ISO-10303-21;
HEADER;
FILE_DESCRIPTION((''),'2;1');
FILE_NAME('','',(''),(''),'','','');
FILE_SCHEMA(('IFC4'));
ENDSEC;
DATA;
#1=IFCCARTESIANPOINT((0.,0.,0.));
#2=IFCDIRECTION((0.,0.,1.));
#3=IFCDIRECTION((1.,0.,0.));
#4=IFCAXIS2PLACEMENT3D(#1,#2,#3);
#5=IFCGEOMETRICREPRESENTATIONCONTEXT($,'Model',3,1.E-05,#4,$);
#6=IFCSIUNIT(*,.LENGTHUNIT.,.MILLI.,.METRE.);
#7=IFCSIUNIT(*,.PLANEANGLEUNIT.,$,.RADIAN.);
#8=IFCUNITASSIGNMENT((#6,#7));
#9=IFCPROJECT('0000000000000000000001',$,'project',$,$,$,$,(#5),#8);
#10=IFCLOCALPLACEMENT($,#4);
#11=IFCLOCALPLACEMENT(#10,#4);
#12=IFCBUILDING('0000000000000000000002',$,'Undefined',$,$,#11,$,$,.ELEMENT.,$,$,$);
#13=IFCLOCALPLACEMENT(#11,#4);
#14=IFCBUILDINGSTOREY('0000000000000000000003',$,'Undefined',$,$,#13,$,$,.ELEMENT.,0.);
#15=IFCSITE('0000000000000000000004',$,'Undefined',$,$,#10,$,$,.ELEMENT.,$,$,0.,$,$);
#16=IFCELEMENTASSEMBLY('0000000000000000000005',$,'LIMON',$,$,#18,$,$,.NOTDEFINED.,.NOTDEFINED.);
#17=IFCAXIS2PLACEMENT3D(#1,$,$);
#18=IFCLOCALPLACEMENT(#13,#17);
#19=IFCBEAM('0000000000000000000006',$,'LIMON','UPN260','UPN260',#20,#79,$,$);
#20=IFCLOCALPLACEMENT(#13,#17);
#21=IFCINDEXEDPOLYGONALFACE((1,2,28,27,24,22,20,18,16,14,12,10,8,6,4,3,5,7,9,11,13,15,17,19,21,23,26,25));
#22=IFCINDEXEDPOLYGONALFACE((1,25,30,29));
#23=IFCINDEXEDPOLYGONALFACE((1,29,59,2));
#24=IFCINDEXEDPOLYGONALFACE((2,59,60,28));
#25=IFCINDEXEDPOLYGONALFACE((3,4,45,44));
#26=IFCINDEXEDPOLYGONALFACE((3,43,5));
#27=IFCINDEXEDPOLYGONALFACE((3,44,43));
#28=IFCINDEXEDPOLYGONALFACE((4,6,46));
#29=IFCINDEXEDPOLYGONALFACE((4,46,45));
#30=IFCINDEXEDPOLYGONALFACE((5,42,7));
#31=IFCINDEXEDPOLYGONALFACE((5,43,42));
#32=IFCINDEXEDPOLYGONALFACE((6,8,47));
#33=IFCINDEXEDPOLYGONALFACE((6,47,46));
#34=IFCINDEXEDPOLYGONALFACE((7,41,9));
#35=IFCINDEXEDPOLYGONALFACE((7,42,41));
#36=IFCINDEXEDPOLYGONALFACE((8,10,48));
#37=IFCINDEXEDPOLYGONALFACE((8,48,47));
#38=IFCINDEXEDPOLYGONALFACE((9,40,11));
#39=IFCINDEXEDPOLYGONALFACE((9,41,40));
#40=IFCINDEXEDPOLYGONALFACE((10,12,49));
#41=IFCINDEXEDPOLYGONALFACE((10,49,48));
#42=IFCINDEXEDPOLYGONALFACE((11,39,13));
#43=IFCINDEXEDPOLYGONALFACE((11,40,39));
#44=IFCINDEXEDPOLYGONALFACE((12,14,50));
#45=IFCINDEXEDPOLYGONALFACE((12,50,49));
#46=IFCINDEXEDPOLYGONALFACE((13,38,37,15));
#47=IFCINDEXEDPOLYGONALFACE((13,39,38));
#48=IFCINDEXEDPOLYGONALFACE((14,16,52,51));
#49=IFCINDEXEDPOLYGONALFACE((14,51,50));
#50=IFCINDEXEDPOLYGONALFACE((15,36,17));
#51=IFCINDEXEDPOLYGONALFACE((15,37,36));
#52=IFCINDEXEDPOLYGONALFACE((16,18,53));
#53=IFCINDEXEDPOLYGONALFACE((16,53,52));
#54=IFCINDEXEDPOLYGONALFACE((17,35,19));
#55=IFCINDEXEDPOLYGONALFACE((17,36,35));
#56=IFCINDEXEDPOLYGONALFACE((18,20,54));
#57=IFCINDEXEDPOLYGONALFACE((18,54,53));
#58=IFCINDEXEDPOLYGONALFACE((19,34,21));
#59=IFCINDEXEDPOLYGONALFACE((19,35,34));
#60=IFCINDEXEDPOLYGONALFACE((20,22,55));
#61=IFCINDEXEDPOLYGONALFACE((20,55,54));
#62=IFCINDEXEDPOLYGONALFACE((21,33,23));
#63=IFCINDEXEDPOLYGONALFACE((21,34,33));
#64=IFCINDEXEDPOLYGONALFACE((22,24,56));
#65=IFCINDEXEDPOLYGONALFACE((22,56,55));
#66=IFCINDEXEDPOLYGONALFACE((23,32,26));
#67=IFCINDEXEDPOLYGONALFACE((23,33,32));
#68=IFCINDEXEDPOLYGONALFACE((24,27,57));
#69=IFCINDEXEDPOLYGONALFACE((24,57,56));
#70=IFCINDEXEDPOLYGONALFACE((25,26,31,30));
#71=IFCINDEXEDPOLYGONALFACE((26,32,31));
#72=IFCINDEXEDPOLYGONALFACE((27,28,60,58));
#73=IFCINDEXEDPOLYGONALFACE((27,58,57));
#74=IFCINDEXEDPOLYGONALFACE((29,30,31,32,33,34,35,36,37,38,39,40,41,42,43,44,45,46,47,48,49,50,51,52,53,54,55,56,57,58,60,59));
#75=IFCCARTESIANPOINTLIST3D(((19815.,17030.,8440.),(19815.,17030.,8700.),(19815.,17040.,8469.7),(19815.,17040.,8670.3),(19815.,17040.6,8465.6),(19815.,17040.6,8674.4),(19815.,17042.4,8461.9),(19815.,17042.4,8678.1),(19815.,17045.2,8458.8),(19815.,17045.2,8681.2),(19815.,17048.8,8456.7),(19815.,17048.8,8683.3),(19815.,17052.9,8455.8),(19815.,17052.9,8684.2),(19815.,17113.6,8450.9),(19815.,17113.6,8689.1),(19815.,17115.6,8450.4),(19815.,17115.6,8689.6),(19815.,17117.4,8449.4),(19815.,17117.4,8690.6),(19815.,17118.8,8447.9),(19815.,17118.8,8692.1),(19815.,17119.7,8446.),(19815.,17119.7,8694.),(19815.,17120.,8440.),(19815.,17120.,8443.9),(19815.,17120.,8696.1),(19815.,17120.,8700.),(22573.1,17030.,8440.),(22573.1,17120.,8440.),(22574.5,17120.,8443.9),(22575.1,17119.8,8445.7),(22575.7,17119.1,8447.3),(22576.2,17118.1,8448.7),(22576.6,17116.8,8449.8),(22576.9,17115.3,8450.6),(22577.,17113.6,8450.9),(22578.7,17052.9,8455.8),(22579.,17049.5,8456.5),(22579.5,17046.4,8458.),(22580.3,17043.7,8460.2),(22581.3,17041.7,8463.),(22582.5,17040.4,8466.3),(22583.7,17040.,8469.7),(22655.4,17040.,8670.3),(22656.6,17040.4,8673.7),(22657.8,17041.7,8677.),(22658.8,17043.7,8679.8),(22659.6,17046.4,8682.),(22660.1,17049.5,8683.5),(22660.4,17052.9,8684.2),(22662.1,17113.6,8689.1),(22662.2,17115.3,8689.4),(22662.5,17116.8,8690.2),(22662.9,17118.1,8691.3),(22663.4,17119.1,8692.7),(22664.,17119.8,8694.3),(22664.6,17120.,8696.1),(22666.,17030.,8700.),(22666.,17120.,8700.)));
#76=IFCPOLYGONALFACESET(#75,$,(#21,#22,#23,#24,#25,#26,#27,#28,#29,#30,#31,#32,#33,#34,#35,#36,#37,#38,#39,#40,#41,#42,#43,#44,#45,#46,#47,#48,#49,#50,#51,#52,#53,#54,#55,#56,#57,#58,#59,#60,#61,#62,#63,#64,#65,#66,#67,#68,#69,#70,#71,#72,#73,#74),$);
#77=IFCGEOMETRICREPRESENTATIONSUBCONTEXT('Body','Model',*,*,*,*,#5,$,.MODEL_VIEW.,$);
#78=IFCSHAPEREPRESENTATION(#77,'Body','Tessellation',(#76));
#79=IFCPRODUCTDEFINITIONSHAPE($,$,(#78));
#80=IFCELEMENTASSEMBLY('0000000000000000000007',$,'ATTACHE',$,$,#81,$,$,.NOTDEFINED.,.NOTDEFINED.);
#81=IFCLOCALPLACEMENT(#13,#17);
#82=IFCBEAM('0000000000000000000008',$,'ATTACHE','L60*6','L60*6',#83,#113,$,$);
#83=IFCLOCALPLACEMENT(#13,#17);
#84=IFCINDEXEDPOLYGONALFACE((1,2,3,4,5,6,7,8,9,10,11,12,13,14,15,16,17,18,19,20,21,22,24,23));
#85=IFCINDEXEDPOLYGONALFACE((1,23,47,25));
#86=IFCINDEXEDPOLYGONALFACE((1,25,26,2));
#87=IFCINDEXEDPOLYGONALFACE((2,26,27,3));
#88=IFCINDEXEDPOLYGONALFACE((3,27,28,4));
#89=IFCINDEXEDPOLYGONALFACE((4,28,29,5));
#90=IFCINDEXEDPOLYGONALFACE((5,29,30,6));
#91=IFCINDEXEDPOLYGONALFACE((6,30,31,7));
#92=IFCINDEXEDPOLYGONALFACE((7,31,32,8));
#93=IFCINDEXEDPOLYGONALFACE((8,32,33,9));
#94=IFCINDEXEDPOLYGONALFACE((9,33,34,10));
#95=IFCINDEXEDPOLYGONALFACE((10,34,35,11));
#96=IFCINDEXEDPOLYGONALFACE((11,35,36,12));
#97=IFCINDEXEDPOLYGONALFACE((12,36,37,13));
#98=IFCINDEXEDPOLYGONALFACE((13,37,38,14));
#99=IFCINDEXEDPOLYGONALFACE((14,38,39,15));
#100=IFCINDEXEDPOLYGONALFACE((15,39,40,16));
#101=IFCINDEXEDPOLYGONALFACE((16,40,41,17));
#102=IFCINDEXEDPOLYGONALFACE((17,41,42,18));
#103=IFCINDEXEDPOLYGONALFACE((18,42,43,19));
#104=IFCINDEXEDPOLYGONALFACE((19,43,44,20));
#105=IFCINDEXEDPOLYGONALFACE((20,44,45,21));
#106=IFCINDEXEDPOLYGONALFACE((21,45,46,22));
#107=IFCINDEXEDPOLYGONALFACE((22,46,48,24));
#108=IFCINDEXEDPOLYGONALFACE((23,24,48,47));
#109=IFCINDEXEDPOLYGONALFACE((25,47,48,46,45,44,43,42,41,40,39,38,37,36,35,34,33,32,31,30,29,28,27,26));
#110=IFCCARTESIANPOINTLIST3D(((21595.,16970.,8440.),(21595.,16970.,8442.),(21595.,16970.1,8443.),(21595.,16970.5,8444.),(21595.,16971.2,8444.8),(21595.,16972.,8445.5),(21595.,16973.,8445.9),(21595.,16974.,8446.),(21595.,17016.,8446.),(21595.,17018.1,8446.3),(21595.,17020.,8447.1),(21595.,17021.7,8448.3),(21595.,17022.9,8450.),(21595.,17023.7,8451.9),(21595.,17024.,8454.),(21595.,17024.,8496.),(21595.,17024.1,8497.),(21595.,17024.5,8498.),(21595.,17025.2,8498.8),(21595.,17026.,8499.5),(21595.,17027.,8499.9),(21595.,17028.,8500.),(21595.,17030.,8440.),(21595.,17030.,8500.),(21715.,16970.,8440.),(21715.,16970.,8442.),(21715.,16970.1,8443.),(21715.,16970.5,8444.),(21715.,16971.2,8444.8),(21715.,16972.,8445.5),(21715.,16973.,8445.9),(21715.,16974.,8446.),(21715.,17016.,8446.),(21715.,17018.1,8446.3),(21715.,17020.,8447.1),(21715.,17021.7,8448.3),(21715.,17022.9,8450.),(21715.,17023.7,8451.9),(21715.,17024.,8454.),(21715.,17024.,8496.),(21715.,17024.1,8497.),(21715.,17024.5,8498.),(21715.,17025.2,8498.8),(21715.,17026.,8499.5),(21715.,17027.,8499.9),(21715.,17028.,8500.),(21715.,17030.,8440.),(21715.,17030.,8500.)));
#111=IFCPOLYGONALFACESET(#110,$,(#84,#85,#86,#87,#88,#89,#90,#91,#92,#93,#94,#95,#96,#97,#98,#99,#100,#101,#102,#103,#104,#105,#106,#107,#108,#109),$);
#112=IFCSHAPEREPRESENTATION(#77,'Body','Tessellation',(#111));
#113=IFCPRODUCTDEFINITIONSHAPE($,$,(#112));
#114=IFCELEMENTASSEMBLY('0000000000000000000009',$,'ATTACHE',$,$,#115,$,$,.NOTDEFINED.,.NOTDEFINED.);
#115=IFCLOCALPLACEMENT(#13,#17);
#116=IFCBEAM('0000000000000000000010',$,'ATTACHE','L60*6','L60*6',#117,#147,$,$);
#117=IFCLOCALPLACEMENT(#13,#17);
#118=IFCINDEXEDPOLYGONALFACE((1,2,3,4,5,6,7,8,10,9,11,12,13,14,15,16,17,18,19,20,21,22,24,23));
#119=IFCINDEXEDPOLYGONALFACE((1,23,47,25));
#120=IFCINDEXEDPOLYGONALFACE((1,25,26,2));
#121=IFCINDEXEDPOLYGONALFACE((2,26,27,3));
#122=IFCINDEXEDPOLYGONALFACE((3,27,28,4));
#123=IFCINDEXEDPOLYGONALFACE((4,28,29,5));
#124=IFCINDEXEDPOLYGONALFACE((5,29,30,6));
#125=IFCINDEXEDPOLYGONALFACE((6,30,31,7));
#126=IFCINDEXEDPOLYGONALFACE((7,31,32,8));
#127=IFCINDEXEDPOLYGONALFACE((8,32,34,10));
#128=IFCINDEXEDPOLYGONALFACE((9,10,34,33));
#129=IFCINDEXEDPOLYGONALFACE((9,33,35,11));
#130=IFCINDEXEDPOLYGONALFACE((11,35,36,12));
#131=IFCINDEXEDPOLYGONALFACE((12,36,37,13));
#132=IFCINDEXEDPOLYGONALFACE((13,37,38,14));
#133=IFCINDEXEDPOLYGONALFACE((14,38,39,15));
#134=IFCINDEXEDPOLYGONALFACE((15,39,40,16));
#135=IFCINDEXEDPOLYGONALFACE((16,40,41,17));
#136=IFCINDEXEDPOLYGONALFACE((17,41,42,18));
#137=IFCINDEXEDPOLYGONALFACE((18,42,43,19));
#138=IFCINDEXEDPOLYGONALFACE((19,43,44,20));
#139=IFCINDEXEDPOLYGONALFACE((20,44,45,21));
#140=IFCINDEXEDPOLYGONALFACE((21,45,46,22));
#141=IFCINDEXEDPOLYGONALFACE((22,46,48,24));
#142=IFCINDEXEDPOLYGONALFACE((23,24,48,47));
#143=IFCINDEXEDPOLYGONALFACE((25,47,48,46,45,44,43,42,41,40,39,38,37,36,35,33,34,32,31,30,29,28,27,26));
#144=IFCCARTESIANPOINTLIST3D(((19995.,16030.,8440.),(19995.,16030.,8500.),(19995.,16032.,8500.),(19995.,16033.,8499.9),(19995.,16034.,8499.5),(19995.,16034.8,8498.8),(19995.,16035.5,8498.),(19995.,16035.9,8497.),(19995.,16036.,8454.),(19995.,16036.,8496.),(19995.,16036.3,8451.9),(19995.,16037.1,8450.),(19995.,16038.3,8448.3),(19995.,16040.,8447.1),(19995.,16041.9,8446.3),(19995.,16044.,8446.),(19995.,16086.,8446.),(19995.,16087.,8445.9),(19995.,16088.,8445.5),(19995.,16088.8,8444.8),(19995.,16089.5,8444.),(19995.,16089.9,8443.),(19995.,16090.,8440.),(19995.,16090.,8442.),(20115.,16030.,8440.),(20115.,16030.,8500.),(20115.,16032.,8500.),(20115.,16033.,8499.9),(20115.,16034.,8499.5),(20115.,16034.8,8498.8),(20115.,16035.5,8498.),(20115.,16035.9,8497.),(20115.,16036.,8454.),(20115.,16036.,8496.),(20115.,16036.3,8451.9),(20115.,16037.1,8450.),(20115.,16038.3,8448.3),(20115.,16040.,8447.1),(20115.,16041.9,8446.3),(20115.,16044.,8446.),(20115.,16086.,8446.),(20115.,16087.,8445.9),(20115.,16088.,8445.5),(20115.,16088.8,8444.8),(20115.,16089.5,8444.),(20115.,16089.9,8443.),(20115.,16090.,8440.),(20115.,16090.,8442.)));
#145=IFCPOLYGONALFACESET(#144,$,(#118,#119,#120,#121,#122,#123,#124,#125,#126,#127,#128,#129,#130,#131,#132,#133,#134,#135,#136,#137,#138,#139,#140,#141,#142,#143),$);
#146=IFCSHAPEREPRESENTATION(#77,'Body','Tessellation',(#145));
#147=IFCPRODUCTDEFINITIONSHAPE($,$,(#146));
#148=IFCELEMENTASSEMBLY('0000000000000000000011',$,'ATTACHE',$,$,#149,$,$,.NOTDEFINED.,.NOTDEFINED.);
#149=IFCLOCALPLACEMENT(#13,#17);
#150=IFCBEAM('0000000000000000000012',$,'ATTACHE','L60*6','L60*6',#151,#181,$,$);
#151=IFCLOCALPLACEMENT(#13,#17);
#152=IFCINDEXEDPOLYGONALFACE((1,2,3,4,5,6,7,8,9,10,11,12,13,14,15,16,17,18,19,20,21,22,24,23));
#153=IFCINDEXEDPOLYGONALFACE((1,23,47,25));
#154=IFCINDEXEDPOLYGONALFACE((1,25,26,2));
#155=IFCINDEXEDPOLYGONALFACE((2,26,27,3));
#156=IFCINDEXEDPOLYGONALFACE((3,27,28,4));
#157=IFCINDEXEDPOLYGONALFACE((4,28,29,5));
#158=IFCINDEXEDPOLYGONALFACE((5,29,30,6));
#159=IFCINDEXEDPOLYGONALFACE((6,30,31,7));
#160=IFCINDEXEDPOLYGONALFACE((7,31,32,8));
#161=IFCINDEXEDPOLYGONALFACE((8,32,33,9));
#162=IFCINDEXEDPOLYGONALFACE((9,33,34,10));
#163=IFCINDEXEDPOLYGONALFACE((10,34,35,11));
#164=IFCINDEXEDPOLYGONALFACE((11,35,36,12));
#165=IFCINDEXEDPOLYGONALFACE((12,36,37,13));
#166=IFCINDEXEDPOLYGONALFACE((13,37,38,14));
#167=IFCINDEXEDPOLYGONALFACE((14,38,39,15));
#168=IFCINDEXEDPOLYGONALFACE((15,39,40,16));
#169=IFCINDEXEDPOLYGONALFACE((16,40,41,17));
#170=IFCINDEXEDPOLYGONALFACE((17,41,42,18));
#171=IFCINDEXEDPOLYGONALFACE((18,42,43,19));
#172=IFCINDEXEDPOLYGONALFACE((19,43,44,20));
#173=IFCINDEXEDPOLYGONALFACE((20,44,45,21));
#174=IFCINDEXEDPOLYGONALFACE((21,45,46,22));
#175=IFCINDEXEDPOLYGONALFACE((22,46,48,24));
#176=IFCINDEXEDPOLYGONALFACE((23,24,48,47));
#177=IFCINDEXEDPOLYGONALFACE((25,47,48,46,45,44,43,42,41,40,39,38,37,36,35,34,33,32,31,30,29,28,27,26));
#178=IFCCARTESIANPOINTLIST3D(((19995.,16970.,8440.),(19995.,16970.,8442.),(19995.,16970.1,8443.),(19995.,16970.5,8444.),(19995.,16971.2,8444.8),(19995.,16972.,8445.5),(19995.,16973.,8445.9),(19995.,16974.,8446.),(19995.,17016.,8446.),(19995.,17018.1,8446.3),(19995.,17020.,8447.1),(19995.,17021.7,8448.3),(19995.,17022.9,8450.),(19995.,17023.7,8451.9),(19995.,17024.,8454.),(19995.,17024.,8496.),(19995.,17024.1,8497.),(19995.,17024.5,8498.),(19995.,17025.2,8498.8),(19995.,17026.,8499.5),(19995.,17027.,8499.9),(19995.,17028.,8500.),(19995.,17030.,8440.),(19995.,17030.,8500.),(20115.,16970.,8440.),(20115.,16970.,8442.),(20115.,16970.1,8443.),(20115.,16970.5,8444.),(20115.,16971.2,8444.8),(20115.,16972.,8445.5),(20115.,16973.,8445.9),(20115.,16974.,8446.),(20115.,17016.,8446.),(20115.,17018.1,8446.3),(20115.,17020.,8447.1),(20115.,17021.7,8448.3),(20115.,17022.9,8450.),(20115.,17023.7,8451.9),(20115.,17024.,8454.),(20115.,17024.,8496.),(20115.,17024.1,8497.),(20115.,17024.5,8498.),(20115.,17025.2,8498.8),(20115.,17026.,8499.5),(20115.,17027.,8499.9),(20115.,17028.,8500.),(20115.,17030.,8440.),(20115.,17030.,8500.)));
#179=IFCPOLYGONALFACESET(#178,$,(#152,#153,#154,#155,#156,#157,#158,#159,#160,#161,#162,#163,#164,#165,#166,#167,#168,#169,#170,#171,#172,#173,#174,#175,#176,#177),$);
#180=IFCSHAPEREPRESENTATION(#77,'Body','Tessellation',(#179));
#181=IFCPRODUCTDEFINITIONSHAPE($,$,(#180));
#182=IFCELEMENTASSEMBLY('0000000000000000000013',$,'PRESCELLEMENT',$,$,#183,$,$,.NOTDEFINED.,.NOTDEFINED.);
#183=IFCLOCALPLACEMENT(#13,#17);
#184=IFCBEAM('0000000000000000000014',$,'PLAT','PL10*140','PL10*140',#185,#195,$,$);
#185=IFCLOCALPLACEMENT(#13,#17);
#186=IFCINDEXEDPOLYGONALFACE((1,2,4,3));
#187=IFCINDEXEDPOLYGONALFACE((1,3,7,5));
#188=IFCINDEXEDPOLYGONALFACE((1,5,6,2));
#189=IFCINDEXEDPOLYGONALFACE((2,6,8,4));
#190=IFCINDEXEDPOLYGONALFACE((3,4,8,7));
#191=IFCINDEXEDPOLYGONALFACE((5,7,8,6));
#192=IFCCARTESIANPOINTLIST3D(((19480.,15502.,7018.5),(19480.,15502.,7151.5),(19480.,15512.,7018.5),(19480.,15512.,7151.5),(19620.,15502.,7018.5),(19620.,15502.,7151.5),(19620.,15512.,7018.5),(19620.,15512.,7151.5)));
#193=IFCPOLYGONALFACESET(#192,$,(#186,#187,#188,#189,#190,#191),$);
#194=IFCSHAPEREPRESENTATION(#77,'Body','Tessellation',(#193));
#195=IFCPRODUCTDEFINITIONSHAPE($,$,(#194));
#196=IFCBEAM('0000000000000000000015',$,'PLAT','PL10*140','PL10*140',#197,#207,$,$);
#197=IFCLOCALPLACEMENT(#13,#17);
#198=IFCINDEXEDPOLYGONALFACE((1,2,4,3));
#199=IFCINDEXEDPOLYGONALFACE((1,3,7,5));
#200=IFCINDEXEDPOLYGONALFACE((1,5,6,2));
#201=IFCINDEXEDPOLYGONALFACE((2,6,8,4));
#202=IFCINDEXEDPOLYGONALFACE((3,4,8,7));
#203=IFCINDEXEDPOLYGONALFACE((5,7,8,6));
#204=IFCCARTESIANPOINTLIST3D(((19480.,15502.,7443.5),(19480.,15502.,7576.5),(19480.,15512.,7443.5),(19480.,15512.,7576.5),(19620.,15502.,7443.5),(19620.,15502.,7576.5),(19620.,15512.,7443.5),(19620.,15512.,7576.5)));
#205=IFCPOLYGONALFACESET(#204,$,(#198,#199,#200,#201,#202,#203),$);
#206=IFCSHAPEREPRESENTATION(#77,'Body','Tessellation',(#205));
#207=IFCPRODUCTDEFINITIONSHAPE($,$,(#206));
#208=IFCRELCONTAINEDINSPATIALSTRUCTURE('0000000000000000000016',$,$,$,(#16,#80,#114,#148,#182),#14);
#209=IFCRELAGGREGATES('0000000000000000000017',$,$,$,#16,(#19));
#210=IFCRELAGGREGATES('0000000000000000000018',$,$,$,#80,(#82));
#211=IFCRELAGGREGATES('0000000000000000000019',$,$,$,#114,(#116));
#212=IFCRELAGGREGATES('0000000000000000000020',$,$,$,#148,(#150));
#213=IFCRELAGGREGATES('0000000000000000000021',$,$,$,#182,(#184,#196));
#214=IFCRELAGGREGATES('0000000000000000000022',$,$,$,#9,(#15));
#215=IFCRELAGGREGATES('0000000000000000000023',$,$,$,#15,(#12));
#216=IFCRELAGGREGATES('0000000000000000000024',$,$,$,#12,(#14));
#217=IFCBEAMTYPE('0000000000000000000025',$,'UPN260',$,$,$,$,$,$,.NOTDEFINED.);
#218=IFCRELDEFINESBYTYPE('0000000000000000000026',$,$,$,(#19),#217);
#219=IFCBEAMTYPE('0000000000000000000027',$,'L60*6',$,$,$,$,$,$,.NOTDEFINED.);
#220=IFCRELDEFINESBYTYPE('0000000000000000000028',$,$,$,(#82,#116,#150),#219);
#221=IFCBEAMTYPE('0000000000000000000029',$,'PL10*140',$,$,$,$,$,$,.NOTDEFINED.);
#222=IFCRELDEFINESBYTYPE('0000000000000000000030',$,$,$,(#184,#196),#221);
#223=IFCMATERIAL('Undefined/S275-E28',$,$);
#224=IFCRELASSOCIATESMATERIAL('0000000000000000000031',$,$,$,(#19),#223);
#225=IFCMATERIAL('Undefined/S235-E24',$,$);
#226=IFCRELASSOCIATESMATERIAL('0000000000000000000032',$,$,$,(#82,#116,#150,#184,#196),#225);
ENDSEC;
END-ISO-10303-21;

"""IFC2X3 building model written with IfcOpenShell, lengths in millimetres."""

from ifc_helpers import new_model, si_unit, frame, origin_with_axes, origin_2d_with_axis, place, context, subcontext, project, spatial, rectangle, l_section, u_section, extrude, clip, halfspace, material, type_object, element, aggregate, save


model = new_model("IFC2X3")

# Units and contexts
model_context = context("Model", 3, precision=1e-05, world=origin_with_axes())
body_context = subcontext(model_context, "Body", "Model", "MODEL_VIEW")
ifc_project = project(units=[si_unit("LENGTHUNIT", "METRE", prefix="MILLI"), si_unit("PLANEANGLEUNIT", "RADIAN")], contexts=[model_context])

# Site, building, storey
site_placement = place(None, origin_with_axes())
site = spatial("IfcSite", under=ifc_project, at=site_placement, Name="Undefined", CompositionType="ELEMENT", RefElevation=0.0)
building_placement = place(site_placement, origin_with_axes())
building = spatial("IfcBuilding", under=site, at=building_placement, Name="Undefined", CompositionType="ELEMENT")
storey_placement = place(building_placement, origin_with_axes())
storey = spatial("IfcBuildingStorey", under=building, at=storey_placement, Name="Undefined", CompositionType="ELEMENT", Elevation=0.0)

# Shared definitions
ifc_material_1 = material(Name="Undefined/S235-E24")

# Element assemblies, beams
assembly_1_placement = place(storey_placement, origin_with_axes())
assembly_1 = element("IfcElementAssembly", 1, at=assembly_1_placement, inside=storey, Name="LIMON", AssemblyPlace="NOTDEFINED", PredefinedType="NOTDEFINED")
ifc_material_2 = material(Name="Undefined/S275-E28")
beam_type_1 = type_object("IfcBeamType", Name="UPN260", PredefinedType="NOTDEFINED")
beam_1_placement = place(assembly_1_placement, frame((19815.0, 17075.0, 8570.0), z_axis=(0.0, 0.0, -1.0), x_axis=(1.0, -0.000002, 0.0)))
beam_1 = element("IfcBeam", 2, at=beam_1_placement, type_object=beam_type_1, material=ifc_material_2, Name="LIMON", Description="UPN260", ObjectType="UPN260", context=body_context, shape_type="Clipping", body=[
    clip(extrude(u_section(Depth=260.0, FlangeWidth=90.0, WebThickness=10.0, FlangeThickness=14.0, FilletRadius=14.0, EdgeRadius=7.0, FlangeSlope=0.07983, at=origin_2d_with_axis()), frame((2851.5, 0.0, 0.0), z_axis=(-1.0, 0.0, 0.0), x_axis=(0.0, -1.0, 0.0)), (0.0, 0.0, 1.0), 2851.5), halfspace(frame((2851.0, 1045.0, -130.0), z_axis=(0.941671, -0.000001, 0.336535), x_axis=(-0.000002, -1.0, 0.0)), False)),
])
aggregate(assembly_1, [beam_1])
assembly_2_placement = place(storey_placement, origin_with_axes())
assembly_2 = element("IfcElementAssembly", 3, at=assembly_2_placement, inside=storey, Name="ATTACHE", AssemblyPlace="NOTDEFINED", PredefinedType="NOTDEFINED")
beam_type_2 = type_object("IfcBeamType", Name="L60*6", PredefinedType="NOTDEFINED")
beam_2_placement = place(assembly_2_placement, frame((21595.0, 17000.0, 8470.0), z_axis=(0.0, 0.0, 1.0), x_axis=(1.0, 0.0, 0.0)))
beam_2 = element("IfcBeam", 4, at=beam_2_placement, type_object=beam_type_2, material=ifc_material_1, Name="ATTACHE", Description="L60*6", ObjectType="L60*6", context=body_context, shape_type="SweptSolid", body=[
    extrude(l_section(Depth=60.0, Width=60.0, Thickness=6.0, FilletRadius=8.0, EdgeRadius=4.0, at=origin_2d_with_axis()), frame((120.0, 0.0, 0.0), z_axis=(-1.0, 0.0, 0.0), x_axis=(0.0, -1.0, 0.0)), (0.0, 0.0, 1.0), 120.0),
])
aggregate(assembly_2, [beam_2])
assembly_3_placement = place(storey_placement, origin_with_axes())
assembly_3 = element("IfcElementAssembly", 5, at=assembly_3_placement, inside=storey, Name="ATTACHE", AssemblyPlace="NOTDEFINED", PredefinedType="NOTDEFINED")
beam_3_placement = place(assembly_3_placement, frame((20115.0, 16060.0, 8470.0), z_axis=(0.0, 0.0, 1.0), x_axis=(-1.0, 0.0, 0.0)))
beam_3 = element("IfcBeam", 6, at=beam_3_placement, type_object=beam_type_2, material=ifc_material_1, Name="ATTACHE", Description="L60*6", ObjectType="L60*6", context=body_context, shape_type="SweptSolid", body=[
    extrude(l_section(Depth=60.0, Width=60.0, Thickness=6.0, FilletRadius=8.0, EdgeRadius=4.0, at=origin_2d_with_axis()), frame((120.0, 0.0, 0.0), z_axis=(-1.0, 0.0, 0.0), x_axis=(0.0, -1.0, 0.0)), (0.0, 0.0, 1.0), 120.0),
])
aggregate(assembly_3, [beam_3])
assembly_4_placement = place(storey_placement, origin_with_axes())
assembly_4 = element("IfcElementAssembly", 7, at=assembly_4_placement, inside=storey, Name="ATTACHE", AssemblyPlace="NOTDEFINED", PredefinedType="NOTDEFINED")
beam_4_placement = place(assembly_4_placement, frame((19995.0, 17000.0, 8470.0), z_axis=(0.0, 0.0, 1.0), x_axis=(1.0, 0.0, 0.0)))
beam_4 = element("IfcBeam", 8, at=beam_4_placement, type_object=beam_type_2, material=ifc_material_1, Name="ATTACHE", Description="L60*6", ObjectType="L60*6", context=body_context, shape_type="SweptSolid", body=[
    extrude(l_section(Depth=60.0, Width=60.0, Thickness=6.0, FilletRadius=8.0, EdgeRadius=4.0, at=origin_2d_with_axis()), frame((120.0, 0.0, 0.0), z_axis=(-1.0, 0.0, 0.0), x_axis=(0.0, -1.0, 0.0)), (0.0, 0.0, 1.0), 120.0),
])
aggregate(assembly_4, [beam_4])

# Element assembly, beams
assembly_5_placement = place(storey_placement, origin_with_axes())
assembly_5 = element("IfcElementAssembly", 9, at=assembly_5_placement, inside=storey, Name="PRESCELLEMENT", AssemblyPlace="NOTDEFINED", PredefinedType="NOTDEFINED")
beam_type_3 = type_object("IfcBeamType", Name="PL10*140", PredefinedType="NOTDEFINED")
beam_5_placement = place(assembly_5_placement, frame((19550.0, 15507.0, 7151.5), z_axis=(-1.0, 0.0, 0.0), x_axis=(0.0, 0.0, -1.0)))
beam_5 = element("IfcBeam", 10, at=beam_5_placement, type_object=beam_type_3, material=ifc_material_1, Name="PLAT", Description="PL10*140", ObjectType="PL10*140", context=body_context, shape_type="SweptSolid", body=[
    extrude(rectangle(XDim=10.0, YDim=140.0, at=origin_2d_with_axis()), frame((133.0, 0.0, 0.0), z_axis=(-1.0, 0.0, 0.0), x_axis=(0.0, -1.0, 0.0)), (0.0, 0.0, 1.0), 133.0),
])
beam_6_placement = place(assembly_5_placement, frame((19550.0, 15507.0, 7576.5), z_axis=(-1.0, 0.0, 0.0), x_axis=(0.0, 0.0, -1.0)))
beam_6 = element("IfcBeam", 11, at=beam_6_placement, type_object=beam_type_3, material=ifc_material_1, Name="PLAT", Description="PL10*140", ObjectType="PL10*140", context=body_context, shape_type="SweptSolid", body=[
    extrude(rectangle(XDim=10.0, YDim=140.0, at=origin_2d_with_axis()), frame((133.0, 0.0, 0.0), z_axis=(-1.0, 0.0, 0.0), x_axis=(0.0, -1.0, 0.0)), (0.0, 0.0, 1.0), 133.0),
])
aggregate(assembly_5, [beam_5, beam_6])

save(model, "model.ifc")
